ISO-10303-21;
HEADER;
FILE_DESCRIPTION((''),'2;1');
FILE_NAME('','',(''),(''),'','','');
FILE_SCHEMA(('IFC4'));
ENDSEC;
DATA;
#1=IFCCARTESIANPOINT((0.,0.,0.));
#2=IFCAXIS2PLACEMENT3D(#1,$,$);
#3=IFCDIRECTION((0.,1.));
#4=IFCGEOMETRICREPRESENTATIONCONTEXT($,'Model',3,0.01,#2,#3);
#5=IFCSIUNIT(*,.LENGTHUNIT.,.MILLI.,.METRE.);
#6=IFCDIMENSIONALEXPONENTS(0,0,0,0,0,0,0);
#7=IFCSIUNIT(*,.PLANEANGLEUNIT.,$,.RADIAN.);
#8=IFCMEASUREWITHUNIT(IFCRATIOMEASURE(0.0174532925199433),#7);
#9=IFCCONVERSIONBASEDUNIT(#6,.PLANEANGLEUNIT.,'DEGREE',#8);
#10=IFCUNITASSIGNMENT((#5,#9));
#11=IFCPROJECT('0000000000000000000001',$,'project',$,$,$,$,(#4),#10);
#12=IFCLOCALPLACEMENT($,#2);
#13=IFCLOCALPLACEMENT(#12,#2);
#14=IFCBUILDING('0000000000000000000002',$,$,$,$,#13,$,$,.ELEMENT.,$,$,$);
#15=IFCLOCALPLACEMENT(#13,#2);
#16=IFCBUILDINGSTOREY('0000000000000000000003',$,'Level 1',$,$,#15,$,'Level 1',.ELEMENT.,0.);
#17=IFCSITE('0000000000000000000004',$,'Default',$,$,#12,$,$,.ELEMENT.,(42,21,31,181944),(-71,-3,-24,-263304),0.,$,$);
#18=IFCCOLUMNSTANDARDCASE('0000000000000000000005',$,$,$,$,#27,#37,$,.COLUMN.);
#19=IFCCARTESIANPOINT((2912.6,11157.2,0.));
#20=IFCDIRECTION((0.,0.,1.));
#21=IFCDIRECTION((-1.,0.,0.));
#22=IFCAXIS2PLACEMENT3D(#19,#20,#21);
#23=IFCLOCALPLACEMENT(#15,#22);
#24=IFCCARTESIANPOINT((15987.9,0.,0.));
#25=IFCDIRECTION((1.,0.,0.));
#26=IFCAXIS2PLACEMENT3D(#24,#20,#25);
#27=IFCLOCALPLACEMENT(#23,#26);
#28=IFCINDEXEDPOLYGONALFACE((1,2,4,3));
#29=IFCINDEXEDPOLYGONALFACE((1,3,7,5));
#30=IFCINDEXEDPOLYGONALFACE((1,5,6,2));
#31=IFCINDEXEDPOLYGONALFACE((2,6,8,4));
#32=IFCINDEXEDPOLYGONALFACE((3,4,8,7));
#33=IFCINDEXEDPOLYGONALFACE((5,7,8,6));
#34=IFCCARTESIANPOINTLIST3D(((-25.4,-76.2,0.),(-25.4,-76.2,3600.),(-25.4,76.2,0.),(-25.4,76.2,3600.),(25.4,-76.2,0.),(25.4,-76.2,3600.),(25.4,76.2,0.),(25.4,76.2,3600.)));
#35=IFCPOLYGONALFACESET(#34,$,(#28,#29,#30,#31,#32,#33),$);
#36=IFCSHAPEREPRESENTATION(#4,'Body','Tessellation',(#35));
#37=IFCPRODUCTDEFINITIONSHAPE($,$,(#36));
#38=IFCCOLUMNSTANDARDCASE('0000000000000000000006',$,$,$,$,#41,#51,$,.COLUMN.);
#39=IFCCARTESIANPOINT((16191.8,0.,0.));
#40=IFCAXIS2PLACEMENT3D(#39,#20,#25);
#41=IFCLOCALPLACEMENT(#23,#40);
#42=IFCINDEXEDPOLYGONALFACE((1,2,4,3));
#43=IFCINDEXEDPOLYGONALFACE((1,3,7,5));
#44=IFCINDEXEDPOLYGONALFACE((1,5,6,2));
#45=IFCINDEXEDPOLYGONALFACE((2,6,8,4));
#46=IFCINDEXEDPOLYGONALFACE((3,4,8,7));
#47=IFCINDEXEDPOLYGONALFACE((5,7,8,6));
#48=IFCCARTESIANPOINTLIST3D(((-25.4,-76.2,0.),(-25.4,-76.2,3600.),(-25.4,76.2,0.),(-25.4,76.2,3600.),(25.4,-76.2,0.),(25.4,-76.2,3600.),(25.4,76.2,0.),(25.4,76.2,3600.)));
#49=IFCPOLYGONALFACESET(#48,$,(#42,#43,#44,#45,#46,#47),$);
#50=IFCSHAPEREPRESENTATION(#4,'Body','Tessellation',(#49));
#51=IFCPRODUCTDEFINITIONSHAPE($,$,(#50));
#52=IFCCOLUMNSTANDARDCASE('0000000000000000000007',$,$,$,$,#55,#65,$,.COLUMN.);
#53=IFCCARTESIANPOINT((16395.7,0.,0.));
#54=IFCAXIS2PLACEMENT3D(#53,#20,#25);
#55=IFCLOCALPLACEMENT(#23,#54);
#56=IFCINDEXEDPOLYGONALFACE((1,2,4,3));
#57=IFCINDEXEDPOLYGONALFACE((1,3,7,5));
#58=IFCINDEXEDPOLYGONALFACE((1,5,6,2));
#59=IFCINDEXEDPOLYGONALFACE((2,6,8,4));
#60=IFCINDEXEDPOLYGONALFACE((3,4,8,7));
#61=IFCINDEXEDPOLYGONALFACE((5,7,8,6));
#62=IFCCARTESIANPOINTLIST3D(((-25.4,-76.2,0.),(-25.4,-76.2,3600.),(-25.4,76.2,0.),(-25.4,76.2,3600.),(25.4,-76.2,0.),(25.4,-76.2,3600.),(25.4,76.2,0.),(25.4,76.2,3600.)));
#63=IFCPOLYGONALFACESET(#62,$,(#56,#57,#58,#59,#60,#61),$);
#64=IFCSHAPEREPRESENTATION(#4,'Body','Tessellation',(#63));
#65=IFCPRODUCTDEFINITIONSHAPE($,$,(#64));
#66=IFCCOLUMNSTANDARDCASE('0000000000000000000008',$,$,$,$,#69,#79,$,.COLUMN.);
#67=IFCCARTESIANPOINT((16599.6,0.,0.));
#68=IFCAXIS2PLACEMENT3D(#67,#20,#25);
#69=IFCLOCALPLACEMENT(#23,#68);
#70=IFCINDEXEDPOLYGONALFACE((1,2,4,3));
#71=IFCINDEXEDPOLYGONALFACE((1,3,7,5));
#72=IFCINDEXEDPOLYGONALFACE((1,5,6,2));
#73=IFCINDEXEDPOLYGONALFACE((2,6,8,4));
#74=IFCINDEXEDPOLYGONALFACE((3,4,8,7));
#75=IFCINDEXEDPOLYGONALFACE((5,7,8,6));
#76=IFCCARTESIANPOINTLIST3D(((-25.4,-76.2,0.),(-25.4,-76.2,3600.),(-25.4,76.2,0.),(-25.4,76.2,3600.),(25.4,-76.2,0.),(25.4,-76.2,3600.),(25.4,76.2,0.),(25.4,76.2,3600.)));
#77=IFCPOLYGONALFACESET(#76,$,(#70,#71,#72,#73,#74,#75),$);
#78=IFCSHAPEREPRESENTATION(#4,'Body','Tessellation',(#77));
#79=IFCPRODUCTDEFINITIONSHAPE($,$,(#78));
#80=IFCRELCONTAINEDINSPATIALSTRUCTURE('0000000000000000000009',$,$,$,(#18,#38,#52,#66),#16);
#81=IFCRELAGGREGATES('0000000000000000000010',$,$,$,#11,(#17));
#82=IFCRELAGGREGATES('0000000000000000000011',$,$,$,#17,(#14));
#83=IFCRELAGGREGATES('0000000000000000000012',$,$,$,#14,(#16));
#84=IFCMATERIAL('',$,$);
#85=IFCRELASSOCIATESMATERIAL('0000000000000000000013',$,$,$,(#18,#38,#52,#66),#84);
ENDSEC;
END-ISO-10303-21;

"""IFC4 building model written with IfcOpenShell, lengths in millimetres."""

from ifc_helpers import new_model, entity, si_unit, converted_unit, direction, frame, origin, place, context, project, spatial, rectangle, extrude, material, element, save


model = new_model("IFC4")

# Units and contexts
model_context = context("Model", 3, precision=0.01, world=origin(), true_north=direction((0.0, 1.0)))
ifc_project = project(units=[si_unit("LENGTHUNIT", "METRE", prefix="MILLI"), converted_unit("PLANEANGLEUNIT", "DEGREE", entity("IfcRatioMeasure", 0.0174532925199433), si_unit("PLANEANGLEUNIT", "RADIAN"), dimensions=[0, 0, 0, 0, 0, 0, 0])], contexts=[model_context])

# Site, building, storey
site_placement = place(None, origin())
site = spatial("IfcSite", under=ifc_project, at=site_placement, Name="Default", CompositionType="ELEMENT", RefLatitude=(42, 21, 31, 181944), RefLongitude=(-71, -3, -24, -263304), RefElevation=0.0)
building_placement = place(site_placement, origin())
building = spatial("IfcBuilding", under=site, at=building_placement, CompositionType="ELEMENT")
storey_placement = place(building_placement, origin())
storey = spatial("IfcBuildingStorey", under=building, at=storey_placement, Name="Level 1", LongName="Level 1", CompositionType="ELEMENT", Elevation=0.0)

# Columns
ifc_material_1 = material(Name="")
placement_1 = place(storey_placement, frame((2912.6, 11157.2, 0.0), z_axis=(0.0, 0.0, 1.0), x_axis=(-1.0, 0.0, 0.0)))
for number, where, z_axis, x_axis in (
    (1, (15987.9, 0.0, 0.0), (0.0, 0.0, 1.0), (1.0, 0.0, 0.0)),
    (2, (16191.8, 0.0, 0.0), (0.0, 0.0, 1.0), (1.0, 0.0, 0.0)),
    (3, (16395.7, 0.0, 0.0), (0.0, 0.0, 1.0), (1.0, 0.0, 0.0)),
    (4, (16599.6, 0.0, 0.0), (0.0, 0.0, 1.0), (1.0, 0.0, 0.0)),
):
    element("IfcColumnStandardCase", number, at=place(placement_1, frame(where, z_axis=z_axis, x_axis=x_axis)), inside=storey, material=ifc_material_1, PredefinedType="COLUMN", context=model_context, shape_type="SweptSolid", body=[
        extrude(rectangle(XDim=50.8, YDim=152.4), origin(), (0.0, 0.0, 1.0), 3600.0),
    ])

save(model, "model.ifc")
